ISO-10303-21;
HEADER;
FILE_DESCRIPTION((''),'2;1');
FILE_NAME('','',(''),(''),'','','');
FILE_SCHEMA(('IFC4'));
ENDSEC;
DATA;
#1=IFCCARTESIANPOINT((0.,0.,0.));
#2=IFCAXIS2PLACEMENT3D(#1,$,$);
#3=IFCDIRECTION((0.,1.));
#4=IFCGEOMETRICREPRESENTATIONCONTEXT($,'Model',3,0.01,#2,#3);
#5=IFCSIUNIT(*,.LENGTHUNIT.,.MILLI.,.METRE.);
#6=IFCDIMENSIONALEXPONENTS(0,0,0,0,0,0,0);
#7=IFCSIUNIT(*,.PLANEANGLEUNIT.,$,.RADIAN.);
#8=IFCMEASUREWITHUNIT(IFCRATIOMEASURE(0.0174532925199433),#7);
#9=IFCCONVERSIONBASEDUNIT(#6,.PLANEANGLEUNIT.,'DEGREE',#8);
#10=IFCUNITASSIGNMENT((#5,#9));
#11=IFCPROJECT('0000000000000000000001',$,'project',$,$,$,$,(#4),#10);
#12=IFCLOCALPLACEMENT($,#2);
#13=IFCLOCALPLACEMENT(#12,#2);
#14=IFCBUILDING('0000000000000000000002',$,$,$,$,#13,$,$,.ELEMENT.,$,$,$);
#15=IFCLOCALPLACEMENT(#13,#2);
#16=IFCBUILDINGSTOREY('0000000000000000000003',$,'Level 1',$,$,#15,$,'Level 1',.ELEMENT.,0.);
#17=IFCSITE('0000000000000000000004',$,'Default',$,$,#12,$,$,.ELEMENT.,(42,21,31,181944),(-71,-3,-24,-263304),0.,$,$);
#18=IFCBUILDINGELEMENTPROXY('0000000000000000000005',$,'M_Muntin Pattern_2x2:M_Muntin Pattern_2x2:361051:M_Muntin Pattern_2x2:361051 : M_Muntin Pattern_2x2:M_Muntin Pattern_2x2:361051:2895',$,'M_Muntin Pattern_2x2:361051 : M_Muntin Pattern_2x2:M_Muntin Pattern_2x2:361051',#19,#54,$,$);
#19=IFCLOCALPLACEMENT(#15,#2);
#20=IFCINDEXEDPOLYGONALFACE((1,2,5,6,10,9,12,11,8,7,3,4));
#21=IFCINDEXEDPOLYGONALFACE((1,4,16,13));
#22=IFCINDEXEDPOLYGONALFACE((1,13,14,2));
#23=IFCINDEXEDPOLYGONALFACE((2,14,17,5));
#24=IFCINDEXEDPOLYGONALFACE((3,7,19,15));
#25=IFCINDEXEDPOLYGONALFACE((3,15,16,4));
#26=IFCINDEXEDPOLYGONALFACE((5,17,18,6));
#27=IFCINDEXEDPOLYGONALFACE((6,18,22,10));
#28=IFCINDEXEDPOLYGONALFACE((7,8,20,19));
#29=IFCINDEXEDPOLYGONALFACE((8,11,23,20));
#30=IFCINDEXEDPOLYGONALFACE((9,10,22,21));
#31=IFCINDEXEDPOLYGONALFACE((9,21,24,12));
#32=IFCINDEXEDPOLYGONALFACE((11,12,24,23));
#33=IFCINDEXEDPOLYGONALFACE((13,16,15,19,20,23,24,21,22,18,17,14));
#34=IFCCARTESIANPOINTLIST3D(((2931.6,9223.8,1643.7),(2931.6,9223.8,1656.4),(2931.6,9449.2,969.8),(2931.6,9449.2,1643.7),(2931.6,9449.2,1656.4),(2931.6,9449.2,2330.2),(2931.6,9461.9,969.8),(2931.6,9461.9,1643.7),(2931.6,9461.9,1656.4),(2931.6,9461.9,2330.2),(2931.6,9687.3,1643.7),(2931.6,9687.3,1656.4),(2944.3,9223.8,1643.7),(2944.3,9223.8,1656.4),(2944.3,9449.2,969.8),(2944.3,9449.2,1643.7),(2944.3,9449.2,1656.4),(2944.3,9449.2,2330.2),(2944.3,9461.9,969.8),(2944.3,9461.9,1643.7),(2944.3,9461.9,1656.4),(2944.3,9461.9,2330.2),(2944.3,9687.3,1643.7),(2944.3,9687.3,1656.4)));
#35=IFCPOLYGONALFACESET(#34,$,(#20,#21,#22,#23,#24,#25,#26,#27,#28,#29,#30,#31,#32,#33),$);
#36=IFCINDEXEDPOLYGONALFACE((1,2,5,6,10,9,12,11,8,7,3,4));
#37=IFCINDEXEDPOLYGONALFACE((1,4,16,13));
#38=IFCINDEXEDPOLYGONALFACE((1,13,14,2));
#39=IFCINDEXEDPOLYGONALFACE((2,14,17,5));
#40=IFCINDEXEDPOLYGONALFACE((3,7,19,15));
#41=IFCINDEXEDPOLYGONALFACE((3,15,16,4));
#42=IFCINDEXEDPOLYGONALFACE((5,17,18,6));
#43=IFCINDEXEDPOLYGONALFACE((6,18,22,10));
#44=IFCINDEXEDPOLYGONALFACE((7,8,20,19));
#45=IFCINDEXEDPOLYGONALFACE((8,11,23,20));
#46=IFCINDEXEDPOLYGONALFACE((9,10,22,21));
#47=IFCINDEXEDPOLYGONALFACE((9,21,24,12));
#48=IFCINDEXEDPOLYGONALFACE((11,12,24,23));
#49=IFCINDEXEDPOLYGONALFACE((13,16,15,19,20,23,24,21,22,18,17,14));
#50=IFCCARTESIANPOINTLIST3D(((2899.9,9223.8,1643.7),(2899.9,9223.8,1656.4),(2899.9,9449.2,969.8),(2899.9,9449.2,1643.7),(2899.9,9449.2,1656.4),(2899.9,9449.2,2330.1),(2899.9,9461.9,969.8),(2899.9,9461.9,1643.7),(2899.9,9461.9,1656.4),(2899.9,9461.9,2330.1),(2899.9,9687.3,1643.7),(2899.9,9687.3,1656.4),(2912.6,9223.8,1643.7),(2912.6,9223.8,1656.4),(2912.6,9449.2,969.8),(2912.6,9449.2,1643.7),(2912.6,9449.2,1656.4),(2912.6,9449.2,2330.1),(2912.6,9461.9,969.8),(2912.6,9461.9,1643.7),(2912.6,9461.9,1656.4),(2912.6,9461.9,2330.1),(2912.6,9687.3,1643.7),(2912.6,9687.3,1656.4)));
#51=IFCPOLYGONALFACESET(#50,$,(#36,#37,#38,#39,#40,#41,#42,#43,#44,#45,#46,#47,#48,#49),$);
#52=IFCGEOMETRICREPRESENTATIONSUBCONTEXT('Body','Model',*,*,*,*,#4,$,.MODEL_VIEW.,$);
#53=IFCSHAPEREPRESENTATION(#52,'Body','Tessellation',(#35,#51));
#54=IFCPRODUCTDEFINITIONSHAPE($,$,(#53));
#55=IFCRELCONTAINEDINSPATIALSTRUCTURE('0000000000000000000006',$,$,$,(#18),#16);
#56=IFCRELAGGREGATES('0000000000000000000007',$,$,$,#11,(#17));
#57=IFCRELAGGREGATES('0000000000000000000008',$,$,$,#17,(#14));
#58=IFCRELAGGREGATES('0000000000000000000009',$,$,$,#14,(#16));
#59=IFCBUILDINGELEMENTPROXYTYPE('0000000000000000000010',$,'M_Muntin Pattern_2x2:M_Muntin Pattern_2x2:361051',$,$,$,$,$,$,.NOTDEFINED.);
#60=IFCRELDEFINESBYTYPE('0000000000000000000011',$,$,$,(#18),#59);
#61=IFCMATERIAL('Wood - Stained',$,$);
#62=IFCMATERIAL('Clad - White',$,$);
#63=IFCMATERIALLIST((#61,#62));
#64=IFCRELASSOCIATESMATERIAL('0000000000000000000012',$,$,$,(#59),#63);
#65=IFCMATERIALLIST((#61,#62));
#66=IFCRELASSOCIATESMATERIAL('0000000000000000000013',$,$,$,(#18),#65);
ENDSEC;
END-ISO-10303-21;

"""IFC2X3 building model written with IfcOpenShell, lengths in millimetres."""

from ifc_helpers import new_model, entity, si_unit, converted_unit, direction, frame, origin, place, context, subcontext, project, spatial, polyline, outline, extrude, source, transform, mapped, material, material_list, type_object, type_shapes, element, save


model = new_model("IFC2X3")

# Units and contexts
model_context = context("Model", 3, precision=0.01, world=origin(), true_north=direction((0.0, 1.0)))
body_context = subcontext(model_context, "Body", "Model", "MODEL_VIEW")
ifc_project = project(units=[si_unit("LENGTHUNIT", "METRE", prefix="MILLI"), converted_unit("PLANEANGLEUNIT", "DEGREE", entity("IfcRatioMeasure", 0.0174532925199433), si_unit("PLANEANGLEUNIT", "RADIAN"), dimensions=[0, 0, 0, 0, 0, 0, 0])], contexts=[model_context])

# Site, building, storey
site_placement = place(None, origin())
site = spatial("IfcSite", under=ifc_project, at=site_placement, Name="Default", CompositionType="ELEMENT", RefLatitude=(42, 21, 31, 181944), RefLongitude=(-71, -3, -24, -263304), RefElevation=0.0)
building_placement = place(site_placement, origin())
building = spatial("IfcBuilding", under=site, at=building_placement, CompositionType="ELEMENT")
storey_placement = place(building_placement, origin())
storey = spatial("IfcBuildingStorey", under=building, at=storey_placement, Name="Level 1", LongName="Level 1", CompositionType="ELEMENT", Elevation=0.0)

# Building element proxy
ifc_material_1 = material(Name="Wood - Stained")
ifc_material_2 = material(Name="Clad - White")
ifc_material_list_1 = material_list([ifc_material_1, ifc_material_2])
ifc_material_list_2 = material_list([ifc_material_1, ifc_material_2])
building_element_proxy_type_1 = type_object("IfcBuildingElementProxyType", Name="M_Muntin Pattern_2x2:M_Muntin Pattern_2x2:361051", PredefinedType="NOTDEFINED", material=ifc_material_list_2)
shared_shape_1 = source(origin(), body_context, "Body", "SweptSolid", [
    extrude(outline(polyline([(-6.4, -680.1), (6.3, -680.1), (6.3, -6.4), (231.7, -6.4), (231.7, 6.3), (6.3, 6.3), (6.3, 680.2), (-6.4, 680.2), (-6.4, 6.3), (-231.7, 6.3), (-231.7, -6.4), (-6.4, -6.4), (-6.4, -680.1)])), frame((2931.6, 9455.6, 1650.0), z_axis=(1.0, 0.0, 0.0), x_axis=(0.0, -1.0, 0.0)), (0.0, 0.0, 1.0), 12.7),
    extrude(outline(polyline([(-6.4, -680.1), (6.3, -680.1), (6.3, -6.4), (231.7, -6.4), (231.7, 6.3), (6.3, 6.3), (6.3, 680.2), (-6.4, 680.2), (-6.4, 6.3), (-231.7, 6.3), (-231.7, -6.4), (-6.4, -6.4), (-6.4, -680.1)])), frame((2899.9, 9455.6, 1650.0), z_axis=(1.0, 0.0, 0.0), x_axis=(0.0, -1.0, 0.0)), (0.0, 0.0, 1.0), 12.7),
])
type_shapes(building_element_proxy_type_1, [shared_shape_1])
proxy_1_placement = place(storey_placement, origin())
element("IfcBuildingElementProxy", 1, at=proxy_1_placement, inside=storey, type_object=building_element_proxy_type_1, material=ifc_material_list_1, Name="M_Muntin Pattern_2x2:M_Muntin Pattern_2x2:361051:M_Muntin Pattern_2x2:361051 : M_Muntin Pattern_2x2:M_Muntin Pattern_2x2:361051:2895", ObjectType="M_Muntin Pattern_2x2:361051 : M_Muntin Pattern_2x2:M_Muntin Pattern_2x2:361051", context=body_context, shape_type="MappedRepresentation", body=[
    mapped(shared_shape_1, transform((0.0, 0.0, 0.0), scale=1.0)),
])

save(model, "model.ifc")
